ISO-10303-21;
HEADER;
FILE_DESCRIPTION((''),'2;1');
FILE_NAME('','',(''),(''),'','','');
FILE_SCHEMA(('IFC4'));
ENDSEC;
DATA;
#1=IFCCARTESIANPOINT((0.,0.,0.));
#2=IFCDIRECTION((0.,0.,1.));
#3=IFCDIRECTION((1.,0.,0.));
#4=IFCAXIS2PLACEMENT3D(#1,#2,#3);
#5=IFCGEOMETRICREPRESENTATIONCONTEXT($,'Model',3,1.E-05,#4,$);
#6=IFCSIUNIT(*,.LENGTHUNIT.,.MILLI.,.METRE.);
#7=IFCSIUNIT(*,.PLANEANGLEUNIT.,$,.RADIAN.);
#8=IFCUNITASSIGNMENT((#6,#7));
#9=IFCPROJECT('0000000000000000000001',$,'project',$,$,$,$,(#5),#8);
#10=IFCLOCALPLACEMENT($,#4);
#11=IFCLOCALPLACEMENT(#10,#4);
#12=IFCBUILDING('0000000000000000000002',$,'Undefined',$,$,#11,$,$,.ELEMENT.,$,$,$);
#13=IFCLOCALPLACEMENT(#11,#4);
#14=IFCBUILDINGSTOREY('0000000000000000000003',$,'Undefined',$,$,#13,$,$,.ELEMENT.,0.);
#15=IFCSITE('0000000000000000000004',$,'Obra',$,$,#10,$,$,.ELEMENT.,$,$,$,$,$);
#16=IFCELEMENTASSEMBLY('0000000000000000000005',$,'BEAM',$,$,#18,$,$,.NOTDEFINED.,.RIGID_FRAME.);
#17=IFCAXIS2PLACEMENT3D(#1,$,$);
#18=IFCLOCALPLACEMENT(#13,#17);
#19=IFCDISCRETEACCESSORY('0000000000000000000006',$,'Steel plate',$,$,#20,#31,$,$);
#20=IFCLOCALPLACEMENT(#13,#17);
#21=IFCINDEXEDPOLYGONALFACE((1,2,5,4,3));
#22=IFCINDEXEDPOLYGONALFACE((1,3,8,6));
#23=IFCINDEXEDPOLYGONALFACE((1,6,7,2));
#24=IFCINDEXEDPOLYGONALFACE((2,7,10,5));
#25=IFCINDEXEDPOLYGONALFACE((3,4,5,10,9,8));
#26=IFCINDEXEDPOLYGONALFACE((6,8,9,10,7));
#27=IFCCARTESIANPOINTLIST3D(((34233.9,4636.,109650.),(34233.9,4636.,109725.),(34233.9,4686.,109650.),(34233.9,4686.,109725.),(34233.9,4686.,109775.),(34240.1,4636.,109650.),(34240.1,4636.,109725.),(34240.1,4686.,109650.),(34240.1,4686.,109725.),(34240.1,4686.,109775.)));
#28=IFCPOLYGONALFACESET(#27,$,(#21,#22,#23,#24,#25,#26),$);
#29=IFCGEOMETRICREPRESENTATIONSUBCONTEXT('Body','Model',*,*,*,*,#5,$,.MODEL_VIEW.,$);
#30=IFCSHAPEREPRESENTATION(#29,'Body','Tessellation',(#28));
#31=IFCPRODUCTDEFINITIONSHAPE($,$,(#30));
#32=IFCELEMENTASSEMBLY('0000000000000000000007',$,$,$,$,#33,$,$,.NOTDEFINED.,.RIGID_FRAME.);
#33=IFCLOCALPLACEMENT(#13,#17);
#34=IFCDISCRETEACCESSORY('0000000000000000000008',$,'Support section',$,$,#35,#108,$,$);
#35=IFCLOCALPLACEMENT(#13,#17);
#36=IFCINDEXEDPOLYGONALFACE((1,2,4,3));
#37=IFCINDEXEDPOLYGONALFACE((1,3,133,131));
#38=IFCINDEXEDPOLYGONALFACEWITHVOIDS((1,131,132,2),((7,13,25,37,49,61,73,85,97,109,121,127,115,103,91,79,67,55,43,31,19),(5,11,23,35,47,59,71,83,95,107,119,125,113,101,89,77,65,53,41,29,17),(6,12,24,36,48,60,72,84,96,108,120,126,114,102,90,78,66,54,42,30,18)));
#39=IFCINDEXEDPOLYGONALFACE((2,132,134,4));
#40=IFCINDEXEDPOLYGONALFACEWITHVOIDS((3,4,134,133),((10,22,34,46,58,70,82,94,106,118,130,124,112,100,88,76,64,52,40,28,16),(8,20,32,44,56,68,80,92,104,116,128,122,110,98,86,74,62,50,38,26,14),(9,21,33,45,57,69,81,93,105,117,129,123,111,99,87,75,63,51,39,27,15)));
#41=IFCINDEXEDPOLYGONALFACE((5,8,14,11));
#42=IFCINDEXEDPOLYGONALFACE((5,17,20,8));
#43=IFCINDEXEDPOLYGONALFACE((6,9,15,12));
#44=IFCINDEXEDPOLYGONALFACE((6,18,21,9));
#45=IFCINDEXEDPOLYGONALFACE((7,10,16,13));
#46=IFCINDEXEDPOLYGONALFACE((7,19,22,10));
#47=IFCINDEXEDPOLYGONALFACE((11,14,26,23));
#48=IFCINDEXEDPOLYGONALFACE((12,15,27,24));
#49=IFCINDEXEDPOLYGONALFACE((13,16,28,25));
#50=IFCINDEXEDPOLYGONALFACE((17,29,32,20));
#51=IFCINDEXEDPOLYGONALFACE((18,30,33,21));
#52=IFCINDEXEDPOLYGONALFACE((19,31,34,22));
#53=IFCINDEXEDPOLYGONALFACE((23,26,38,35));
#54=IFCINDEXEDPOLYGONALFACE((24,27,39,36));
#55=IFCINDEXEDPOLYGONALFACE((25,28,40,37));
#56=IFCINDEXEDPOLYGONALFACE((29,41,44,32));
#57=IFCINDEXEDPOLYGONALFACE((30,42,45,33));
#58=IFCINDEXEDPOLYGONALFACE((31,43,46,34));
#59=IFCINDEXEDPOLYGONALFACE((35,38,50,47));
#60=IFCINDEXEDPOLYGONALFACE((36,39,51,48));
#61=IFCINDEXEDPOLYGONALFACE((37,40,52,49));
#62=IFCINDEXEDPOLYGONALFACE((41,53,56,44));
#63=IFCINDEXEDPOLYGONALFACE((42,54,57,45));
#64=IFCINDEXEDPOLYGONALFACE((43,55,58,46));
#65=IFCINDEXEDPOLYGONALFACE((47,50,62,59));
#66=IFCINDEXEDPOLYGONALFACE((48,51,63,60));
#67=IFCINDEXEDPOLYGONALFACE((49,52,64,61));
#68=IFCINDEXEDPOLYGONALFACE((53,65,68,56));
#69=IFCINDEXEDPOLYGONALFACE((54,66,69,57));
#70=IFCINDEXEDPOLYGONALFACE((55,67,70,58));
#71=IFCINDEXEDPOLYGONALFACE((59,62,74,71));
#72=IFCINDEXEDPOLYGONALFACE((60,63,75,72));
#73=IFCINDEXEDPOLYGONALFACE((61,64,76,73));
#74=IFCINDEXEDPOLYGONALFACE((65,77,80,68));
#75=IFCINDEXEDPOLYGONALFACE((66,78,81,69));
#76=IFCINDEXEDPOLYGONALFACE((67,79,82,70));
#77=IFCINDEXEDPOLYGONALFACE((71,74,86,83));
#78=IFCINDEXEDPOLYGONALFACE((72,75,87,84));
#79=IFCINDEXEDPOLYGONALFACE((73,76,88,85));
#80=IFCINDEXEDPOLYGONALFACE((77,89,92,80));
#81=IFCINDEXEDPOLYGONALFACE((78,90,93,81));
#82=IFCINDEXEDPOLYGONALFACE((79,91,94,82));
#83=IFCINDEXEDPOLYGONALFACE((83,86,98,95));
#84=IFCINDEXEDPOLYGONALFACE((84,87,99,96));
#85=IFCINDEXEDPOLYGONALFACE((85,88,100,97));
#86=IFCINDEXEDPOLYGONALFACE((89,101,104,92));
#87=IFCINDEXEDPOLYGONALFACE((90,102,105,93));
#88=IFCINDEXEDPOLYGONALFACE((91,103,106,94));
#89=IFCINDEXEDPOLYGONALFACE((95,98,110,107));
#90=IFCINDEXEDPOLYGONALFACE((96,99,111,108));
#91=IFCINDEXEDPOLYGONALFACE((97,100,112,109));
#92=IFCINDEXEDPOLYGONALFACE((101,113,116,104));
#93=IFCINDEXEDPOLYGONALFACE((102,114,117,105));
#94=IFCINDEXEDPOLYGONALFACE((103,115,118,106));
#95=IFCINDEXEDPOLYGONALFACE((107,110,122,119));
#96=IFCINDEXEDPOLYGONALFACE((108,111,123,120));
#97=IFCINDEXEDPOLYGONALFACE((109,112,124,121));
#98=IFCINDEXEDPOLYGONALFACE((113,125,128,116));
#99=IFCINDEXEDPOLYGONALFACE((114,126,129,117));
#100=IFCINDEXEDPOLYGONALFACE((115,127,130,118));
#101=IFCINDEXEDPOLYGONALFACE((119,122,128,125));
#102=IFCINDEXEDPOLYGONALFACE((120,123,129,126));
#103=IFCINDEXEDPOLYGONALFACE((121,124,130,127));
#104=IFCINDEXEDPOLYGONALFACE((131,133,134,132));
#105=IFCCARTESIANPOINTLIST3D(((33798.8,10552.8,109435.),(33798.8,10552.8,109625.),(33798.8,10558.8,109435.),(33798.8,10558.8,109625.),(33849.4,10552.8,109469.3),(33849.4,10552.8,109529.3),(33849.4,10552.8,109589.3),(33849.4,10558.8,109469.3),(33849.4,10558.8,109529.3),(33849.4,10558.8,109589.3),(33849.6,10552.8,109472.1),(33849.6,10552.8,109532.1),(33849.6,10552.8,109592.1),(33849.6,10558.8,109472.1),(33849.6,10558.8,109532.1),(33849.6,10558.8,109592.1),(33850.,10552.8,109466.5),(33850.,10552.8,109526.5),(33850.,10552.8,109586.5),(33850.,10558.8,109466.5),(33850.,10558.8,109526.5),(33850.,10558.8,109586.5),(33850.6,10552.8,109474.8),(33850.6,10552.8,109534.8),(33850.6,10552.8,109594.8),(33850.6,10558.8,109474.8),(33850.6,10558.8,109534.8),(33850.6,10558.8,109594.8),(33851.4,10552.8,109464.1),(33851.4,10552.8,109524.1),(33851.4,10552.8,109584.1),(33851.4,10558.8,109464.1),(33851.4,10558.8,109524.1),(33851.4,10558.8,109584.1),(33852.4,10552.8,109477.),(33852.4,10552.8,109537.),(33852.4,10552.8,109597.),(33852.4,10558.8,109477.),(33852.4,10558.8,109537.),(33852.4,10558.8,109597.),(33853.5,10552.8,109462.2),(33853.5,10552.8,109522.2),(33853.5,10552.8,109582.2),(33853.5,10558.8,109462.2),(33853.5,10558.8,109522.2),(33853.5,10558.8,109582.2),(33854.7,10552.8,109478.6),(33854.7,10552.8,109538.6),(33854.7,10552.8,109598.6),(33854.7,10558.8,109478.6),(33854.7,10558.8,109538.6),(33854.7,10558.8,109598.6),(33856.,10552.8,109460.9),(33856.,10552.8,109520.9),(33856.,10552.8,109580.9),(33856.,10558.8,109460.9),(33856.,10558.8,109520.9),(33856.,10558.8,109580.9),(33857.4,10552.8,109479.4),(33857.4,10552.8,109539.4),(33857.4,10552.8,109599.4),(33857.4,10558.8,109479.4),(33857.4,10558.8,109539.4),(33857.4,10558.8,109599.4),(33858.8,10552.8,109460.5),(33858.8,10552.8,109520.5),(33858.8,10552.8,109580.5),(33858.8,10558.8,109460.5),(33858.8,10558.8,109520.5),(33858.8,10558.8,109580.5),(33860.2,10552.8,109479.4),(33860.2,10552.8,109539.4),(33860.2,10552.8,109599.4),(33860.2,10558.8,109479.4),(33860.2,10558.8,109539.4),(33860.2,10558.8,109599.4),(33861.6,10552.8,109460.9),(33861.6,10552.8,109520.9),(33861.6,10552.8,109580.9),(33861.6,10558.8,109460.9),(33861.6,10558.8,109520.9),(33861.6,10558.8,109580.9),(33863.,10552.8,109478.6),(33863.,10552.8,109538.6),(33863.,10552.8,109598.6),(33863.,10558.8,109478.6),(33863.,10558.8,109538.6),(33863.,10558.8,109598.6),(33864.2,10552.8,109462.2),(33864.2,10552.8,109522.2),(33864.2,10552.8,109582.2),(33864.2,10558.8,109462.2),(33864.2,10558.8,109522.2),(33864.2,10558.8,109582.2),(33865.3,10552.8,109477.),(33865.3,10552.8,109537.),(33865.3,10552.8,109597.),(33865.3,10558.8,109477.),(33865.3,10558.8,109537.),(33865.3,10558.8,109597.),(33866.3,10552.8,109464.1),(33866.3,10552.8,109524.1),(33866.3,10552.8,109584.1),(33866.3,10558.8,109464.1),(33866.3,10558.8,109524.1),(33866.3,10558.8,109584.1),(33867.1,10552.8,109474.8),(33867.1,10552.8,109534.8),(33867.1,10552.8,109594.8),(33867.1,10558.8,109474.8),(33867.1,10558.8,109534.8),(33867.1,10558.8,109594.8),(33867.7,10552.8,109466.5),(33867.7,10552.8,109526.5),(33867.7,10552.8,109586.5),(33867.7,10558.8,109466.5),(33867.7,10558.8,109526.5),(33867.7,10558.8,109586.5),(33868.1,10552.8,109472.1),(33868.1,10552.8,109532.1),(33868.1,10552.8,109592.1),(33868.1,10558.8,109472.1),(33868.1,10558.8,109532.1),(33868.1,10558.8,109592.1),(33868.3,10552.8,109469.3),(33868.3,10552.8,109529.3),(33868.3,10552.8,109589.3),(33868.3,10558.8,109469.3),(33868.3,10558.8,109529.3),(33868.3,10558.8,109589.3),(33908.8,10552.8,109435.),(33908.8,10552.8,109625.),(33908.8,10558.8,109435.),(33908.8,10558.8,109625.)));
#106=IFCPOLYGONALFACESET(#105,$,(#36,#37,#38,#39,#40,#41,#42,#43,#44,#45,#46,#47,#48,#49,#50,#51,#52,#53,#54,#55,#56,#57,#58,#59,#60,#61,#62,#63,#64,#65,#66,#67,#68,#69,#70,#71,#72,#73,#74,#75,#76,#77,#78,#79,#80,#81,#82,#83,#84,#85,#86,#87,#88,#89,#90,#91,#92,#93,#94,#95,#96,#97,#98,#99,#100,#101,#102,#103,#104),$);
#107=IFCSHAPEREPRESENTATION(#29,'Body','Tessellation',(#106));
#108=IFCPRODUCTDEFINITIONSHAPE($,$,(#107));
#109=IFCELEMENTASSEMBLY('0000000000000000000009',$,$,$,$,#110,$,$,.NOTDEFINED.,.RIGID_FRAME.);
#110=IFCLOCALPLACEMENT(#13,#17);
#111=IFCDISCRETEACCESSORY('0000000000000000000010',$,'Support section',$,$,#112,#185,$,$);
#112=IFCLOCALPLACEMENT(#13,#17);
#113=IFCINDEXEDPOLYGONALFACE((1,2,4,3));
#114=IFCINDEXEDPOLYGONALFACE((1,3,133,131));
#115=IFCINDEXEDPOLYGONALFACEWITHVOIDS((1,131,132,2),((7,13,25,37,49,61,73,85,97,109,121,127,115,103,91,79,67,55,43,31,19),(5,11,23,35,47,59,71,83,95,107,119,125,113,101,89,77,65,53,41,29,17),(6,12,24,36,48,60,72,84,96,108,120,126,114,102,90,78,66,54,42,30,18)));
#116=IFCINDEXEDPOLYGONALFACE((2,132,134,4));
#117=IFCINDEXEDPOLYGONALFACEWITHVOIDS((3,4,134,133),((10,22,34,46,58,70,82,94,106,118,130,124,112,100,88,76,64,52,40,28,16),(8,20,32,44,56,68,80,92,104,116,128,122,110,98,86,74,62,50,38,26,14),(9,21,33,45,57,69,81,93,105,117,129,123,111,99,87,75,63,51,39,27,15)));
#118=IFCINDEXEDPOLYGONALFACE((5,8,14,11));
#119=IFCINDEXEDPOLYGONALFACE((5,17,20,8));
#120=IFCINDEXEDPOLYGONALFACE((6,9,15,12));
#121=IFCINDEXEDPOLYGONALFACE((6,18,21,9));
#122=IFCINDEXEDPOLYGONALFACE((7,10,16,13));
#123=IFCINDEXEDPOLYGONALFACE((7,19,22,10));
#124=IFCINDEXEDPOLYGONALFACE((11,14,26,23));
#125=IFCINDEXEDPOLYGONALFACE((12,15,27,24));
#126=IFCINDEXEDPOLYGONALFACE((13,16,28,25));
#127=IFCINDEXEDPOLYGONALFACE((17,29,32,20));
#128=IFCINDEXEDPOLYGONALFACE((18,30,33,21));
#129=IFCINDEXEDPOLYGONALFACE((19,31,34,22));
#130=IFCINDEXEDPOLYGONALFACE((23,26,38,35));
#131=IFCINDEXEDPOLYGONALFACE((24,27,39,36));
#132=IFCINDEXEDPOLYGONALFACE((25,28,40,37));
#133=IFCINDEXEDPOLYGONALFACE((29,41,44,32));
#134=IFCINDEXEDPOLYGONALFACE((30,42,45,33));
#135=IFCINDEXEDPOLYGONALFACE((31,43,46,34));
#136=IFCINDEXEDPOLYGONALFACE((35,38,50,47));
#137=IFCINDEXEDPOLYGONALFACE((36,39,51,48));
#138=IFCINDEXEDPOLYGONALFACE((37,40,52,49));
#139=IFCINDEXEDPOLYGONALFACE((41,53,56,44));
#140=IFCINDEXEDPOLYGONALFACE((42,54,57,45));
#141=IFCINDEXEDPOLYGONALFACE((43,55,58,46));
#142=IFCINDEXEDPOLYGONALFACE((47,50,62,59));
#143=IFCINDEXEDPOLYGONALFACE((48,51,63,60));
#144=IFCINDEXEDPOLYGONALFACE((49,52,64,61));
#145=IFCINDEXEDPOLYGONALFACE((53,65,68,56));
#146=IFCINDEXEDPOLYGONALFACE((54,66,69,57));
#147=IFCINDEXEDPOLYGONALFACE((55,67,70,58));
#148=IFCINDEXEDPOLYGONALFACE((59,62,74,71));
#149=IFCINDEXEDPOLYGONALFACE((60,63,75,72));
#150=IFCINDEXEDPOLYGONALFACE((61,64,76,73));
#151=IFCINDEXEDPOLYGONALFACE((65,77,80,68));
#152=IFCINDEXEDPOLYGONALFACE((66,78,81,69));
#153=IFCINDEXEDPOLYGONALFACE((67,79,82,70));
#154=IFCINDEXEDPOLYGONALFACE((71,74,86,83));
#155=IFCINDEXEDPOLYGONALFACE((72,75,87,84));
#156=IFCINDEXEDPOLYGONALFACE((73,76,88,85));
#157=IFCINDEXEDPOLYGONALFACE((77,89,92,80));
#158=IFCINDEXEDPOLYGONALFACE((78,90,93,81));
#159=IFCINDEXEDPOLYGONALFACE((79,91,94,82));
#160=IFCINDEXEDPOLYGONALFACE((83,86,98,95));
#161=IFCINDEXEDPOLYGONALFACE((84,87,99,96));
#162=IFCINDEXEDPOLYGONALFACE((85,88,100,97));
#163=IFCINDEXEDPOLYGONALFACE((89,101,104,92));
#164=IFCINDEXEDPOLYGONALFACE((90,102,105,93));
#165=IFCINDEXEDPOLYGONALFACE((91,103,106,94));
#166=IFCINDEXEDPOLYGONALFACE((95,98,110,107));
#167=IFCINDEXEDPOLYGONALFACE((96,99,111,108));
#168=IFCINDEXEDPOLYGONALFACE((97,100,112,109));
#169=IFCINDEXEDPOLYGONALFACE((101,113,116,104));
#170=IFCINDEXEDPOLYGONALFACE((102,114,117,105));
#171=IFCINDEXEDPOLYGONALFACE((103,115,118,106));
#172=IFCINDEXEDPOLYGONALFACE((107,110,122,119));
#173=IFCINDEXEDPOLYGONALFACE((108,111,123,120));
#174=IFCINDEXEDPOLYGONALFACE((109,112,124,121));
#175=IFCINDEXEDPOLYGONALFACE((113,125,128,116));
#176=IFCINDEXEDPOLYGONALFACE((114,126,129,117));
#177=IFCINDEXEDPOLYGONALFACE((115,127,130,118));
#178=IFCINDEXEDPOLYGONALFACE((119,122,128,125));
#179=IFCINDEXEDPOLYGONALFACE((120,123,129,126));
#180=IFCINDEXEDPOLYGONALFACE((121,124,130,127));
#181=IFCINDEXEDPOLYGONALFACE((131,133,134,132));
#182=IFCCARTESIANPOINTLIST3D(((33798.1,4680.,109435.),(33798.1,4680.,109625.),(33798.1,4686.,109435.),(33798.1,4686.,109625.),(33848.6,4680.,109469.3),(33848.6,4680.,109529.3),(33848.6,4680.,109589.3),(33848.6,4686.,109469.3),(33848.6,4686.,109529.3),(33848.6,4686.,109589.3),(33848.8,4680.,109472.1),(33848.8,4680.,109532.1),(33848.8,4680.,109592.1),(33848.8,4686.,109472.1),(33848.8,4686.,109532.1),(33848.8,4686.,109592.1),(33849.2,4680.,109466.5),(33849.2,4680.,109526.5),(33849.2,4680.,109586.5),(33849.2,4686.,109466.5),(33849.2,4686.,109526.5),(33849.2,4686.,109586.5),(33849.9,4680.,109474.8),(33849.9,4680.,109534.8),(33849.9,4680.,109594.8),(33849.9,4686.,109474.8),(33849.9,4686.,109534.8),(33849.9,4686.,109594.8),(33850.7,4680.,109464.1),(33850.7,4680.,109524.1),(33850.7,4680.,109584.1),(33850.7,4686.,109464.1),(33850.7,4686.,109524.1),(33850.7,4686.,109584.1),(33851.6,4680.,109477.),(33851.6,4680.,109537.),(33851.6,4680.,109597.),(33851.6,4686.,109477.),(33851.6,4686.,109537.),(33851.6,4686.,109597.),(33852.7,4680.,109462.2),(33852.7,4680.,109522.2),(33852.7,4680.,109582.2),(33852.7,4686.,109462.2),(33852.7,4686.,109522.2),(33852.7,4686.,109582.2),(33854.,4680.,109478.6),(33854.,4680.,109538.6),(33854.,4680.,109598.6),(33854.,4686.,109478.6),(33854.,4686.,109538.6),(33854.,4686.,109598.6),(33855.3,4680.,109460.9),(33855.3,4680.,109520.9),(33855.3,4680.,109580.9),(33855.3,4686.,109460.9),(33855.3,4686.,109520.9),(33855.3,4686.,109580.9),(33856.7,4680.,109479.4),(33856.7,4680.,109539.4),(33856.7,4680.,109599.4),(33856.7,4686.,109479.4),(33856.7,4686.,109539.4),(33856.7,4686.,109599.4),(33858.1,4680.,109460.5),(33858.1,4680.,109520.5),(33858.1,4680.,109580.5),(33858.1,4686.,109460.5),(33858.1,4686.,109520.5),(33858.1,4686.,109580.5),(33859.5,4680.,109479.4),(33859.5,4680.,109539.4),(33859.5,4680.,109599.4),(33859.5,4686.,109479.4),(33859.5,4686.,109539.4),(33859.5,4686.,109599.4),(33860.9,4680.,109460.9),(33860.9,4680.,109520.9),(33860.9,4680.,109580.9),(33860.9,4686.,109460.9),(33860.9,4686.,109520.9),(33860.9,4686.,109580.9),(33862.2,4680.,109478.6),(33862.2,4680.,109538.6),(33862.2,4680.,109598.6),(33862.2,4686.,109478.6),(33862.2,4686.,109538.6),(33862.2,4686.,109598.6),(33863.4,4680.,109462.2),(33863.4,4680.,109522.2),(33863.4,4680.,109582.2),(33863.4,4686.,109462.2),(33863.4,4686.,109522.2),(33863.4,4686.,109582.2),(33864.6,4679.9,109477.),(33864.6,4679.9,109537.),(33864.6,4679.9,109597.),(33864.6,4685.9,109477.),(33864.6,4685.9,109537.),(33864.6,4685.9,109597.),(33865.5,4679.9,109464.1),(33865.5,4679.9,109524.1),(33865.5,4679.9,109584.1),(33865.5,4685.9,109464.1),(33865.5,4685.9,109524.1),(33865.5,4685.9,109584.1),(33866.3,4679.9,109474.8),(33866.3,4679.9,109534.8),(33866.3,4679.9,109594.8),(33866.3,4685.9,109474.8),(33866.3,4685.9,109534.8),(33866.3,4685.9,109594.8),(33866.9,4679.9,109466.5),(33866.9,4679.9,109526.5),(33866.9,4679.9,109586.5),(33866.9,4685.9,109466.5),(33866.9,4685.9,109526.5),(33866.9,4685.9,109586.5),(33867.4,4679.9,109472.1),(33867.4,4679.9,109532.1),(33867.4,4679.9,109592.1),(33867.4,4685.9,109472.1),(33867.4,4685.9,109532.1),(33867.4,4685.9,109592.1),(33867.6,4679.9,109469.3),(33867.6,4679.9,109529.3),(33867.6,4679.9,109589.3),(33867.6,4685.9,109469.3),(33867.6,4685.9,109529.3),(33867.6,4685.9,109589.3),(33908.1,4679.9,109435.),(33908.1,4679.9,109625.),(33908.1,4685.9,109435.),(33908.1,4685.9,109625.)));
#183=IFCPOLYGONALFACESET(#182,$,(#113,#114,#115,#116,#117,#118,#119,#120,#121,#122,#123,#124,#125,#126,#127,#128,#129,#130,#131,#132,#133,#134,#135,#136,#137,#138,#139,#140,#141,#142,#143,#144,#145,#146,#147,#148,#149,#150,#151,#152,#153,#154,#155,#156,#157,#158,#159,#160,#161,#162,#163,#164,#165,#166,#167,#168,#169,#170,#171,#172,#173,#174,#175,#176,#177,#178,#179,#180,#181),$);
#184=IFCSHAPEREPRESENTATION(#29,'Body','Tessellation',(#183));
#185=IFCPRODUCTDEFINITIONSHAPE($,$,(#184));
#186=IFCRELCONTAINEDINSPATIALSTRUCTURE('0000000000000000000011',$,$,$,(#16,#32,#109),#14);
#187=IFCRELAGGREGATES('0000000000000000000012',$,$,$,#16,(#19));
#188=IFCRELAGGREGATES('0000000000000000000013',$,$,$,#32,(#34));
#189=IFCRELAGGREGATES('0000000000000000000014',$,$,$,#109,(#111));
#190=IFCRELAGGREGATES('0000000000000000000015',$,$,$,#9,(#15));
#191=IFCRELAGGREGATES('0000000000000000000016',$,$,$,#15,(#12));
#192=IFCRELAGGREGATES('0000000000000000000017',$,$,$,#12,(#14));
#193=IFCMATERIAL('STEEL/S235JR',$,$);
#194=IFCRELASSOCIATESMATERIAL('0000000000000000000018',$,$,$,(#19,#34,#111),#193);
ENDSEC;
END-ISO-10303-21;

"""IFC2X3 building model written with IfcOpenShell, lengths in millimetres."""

from ifc_helpers import new_model, si_unit, frame, origin_with_axes, origin_2d_with_axis, place, context, subcontext, project, spatial, polyline, rectangle, circle, outline, extrude, source, transform, mapped, material, element, aggregate, save


model = new_model("IFC2X3")

# Units and contexts
model_context = context("Model", 3, precision=1e-05, world=origin_with_axes())
body_context = subcontext(model_context, "Body", "Model", "MODEL_VIEW")
ifc_project = project(units=[si_unit("LENGTHUNIT", "METRE", prefix="MILLI"), si_unit("PLANEANGLEUNIT", "RADIAN")], contexts=[model_context])

# Site, building, storey
site_placement = place(None, origin_with_axes())
site = spatial("IfcSite", under=ifc_project, at=site_placement, Name="Obra", CompositionType="ELEMENT")
building_placement = place(site_placement, origin_with_axes())
building = spatial("IfcBuilding", under=site, at=building_placement, Name="Undefined", CompositionType="ELEMENT")
storey_placement = place(building_placement, origin_with_axes())
storey = spatial("IfcBuildingStorey", under=building, at=storey_placement, Name="Undefined", CompositionType="ELEMENT", Elevation=0.0)

# Element assembly
assembly_1_placement = place(storey_placement, origin_with_axes())
assembly_1 = element("IfcElementAssembly", 1, at=assembly_1_placement, inside=storey, Name="BEAM", AssemblyPlace="NOTDEFINED", PredefinedType="RIGID_FRAME")
ifc_material_1 = material(Name="STEEL/S235JR")

# Discrete accessory
discrete_accessory_1_placement = place(assembly_1_placement, frame((34237.0, 4686.0, 109725.0), z_axis=(-1.0, 0.0, 0.0), x_axis=(0.0, 0.0, -1.0)))
discrete_accessory_1 = element("IfcDiscreteAccessory", 2, at=discrete_accessory_1_placement, material=ifc_material_1, Name="Steel plate", context=body_context, shape_type="SweptSolid", body=[
    extrude(outline(polyline([(0.0, 0.0), (75.0, 0.0), (75.0, 50.0), (0.0, 50.0), (-75.0, -25.0), (-75.0, 0.0), (0.0, 0.0)])), frame((0.0, 0.0, -3.1), z_axis=(0.0, 0.0, 1.0), x_axis=(1.0, 0.0, 0.0)), (0.0, 0.0, 1.0), 6.2),
])
aggregate(assembly_1, [discrete_accessory_1])

# Element assemblies, discrete accessories, openings
assembly_2_placement = place(storey_placement, origin_with_axes())
assembly_2 = element("IfcElementAssembly", 3, at=assembly_2_placement, inside=storey, AssemblyPlace="NOTDEFINED", PredefinedType="RIGID_FRAME")
discrete_accessory_2_placement = place(assembly_2_placement, frame((33853.8, 10555.8, 109435.0), z_axis=(0.0, 0.0, 1.0), x_axis=(-1.0, 0.000126, 0.0)))
discrete_accessory_2 = element("IfcDiscreteAccessory", 4, at=discrete_accessory_2_placement, material=ifc_material_1, Name="Support section", context=body_context, shape_type="SweptSolid", body=[
    extrude(rectangle(XDim=6.0, YDim=110.0, at=origin_2d_with_axis()), frame((0.0, 0.0, 190.0), z_axis=(0.0, 0.0, -1.0), x_axis=(0.0, 1.0, 0.0)), (0.0, 0.0, 1.0), 190.0),
])
shared_shape_1 = source(origin_with_axes(), body_context, "Body", "SweptSolid", [
    extrude(circle(Radius=9.5, at=origin_2d_with_axis()), frame((0.0, -9.2, 0.0), z_axis=(0.0, 1.0, 0.0), x_axis=(1.0, 0.0, 0.0)), (0.0, 0.0, 1.0), 6.2),
])
opening_1_placement = place(assembly_2_placement, frame((33808.8, 10561.9, 109650.0), z_axis=(1.0, -0.000126, 0.0), x_axis=(0.0, 0.0, -1.0)))
element("IfcOpeningElement", 5, at=opening_1_placement, cuts=discrete_accessory_2, ObjectType="Opening", context=body_context, shape_type="MappedRepresentation", body=[
    mapped(shared_shape_1, transform((60.0, 0.0, 50.0))),
    mapped(shared_shape_1, transform((120.0, 0.0, 50.0))),
    mapped(shared_shape_1, transform((180.0, 0.0, 50.0))),
])
aggregate(assembly_2, [discrete_accessory_2])
assembly_3_placement = place(storey_placement, origin_with_axes())
assembly_3 = element("IfcElementAssembly", 6, at=assembly_3_placement, inside=storey, AssemblyPlace="NOTDEFINED", PredefinedType="RIGID_FRAME")
discrete_accessory_3_placement = place(assembly_3_placement, frame((33853.1, 4683.0, 109435.0), z_axis=(0.0, 0.0, 1.0), x_axis=(-1.0, 0.000126, 0.0)))
discrete_accessory_3 = element("IfcDiscreteAccessory", 7, at=discrete_accessory_3_placement, material=ifc_material_1, Name="Support section", context=body_context, shape_type="SweptSolid", body=[
    extrude(rectangle(XDim=6.0, YDim=110.0, at=origin_2d_with_axis()), frame((0.0, 0.0, 190.0), z_axis=(0.0, 0.0, -1.0), x_axis=(0.0, 1.0, 0.0)), (0.0, 0.0, 1.0), 190.0),
])
opening_2_placement = place(assembly_3_placement, frame((33808.1, 4689.1, 109650.0), z_axis=(1.0, -0.000126, 0.0), x_axis=(0.0, 0.0, -1.0)))
element("IfcOpeningElement", 8, at=opening_2_placement, cuts=discrete_accessory_3, ObjectType="Opening", context=body_context, shape_type="MappedRepresentation", body=[
    mapped(shared_shape_1, transform((60.0, 0.0, 50.0))),
    mapped(shared_shape_1, transform((120.0, 0.0, 50.0))),
    mapped(shared_shape_1, transform((180.0, 0.0, 50.0))),
])
aggregate(assembly_3, [discrete_accessory_3])

save(model, "model.ifc")
